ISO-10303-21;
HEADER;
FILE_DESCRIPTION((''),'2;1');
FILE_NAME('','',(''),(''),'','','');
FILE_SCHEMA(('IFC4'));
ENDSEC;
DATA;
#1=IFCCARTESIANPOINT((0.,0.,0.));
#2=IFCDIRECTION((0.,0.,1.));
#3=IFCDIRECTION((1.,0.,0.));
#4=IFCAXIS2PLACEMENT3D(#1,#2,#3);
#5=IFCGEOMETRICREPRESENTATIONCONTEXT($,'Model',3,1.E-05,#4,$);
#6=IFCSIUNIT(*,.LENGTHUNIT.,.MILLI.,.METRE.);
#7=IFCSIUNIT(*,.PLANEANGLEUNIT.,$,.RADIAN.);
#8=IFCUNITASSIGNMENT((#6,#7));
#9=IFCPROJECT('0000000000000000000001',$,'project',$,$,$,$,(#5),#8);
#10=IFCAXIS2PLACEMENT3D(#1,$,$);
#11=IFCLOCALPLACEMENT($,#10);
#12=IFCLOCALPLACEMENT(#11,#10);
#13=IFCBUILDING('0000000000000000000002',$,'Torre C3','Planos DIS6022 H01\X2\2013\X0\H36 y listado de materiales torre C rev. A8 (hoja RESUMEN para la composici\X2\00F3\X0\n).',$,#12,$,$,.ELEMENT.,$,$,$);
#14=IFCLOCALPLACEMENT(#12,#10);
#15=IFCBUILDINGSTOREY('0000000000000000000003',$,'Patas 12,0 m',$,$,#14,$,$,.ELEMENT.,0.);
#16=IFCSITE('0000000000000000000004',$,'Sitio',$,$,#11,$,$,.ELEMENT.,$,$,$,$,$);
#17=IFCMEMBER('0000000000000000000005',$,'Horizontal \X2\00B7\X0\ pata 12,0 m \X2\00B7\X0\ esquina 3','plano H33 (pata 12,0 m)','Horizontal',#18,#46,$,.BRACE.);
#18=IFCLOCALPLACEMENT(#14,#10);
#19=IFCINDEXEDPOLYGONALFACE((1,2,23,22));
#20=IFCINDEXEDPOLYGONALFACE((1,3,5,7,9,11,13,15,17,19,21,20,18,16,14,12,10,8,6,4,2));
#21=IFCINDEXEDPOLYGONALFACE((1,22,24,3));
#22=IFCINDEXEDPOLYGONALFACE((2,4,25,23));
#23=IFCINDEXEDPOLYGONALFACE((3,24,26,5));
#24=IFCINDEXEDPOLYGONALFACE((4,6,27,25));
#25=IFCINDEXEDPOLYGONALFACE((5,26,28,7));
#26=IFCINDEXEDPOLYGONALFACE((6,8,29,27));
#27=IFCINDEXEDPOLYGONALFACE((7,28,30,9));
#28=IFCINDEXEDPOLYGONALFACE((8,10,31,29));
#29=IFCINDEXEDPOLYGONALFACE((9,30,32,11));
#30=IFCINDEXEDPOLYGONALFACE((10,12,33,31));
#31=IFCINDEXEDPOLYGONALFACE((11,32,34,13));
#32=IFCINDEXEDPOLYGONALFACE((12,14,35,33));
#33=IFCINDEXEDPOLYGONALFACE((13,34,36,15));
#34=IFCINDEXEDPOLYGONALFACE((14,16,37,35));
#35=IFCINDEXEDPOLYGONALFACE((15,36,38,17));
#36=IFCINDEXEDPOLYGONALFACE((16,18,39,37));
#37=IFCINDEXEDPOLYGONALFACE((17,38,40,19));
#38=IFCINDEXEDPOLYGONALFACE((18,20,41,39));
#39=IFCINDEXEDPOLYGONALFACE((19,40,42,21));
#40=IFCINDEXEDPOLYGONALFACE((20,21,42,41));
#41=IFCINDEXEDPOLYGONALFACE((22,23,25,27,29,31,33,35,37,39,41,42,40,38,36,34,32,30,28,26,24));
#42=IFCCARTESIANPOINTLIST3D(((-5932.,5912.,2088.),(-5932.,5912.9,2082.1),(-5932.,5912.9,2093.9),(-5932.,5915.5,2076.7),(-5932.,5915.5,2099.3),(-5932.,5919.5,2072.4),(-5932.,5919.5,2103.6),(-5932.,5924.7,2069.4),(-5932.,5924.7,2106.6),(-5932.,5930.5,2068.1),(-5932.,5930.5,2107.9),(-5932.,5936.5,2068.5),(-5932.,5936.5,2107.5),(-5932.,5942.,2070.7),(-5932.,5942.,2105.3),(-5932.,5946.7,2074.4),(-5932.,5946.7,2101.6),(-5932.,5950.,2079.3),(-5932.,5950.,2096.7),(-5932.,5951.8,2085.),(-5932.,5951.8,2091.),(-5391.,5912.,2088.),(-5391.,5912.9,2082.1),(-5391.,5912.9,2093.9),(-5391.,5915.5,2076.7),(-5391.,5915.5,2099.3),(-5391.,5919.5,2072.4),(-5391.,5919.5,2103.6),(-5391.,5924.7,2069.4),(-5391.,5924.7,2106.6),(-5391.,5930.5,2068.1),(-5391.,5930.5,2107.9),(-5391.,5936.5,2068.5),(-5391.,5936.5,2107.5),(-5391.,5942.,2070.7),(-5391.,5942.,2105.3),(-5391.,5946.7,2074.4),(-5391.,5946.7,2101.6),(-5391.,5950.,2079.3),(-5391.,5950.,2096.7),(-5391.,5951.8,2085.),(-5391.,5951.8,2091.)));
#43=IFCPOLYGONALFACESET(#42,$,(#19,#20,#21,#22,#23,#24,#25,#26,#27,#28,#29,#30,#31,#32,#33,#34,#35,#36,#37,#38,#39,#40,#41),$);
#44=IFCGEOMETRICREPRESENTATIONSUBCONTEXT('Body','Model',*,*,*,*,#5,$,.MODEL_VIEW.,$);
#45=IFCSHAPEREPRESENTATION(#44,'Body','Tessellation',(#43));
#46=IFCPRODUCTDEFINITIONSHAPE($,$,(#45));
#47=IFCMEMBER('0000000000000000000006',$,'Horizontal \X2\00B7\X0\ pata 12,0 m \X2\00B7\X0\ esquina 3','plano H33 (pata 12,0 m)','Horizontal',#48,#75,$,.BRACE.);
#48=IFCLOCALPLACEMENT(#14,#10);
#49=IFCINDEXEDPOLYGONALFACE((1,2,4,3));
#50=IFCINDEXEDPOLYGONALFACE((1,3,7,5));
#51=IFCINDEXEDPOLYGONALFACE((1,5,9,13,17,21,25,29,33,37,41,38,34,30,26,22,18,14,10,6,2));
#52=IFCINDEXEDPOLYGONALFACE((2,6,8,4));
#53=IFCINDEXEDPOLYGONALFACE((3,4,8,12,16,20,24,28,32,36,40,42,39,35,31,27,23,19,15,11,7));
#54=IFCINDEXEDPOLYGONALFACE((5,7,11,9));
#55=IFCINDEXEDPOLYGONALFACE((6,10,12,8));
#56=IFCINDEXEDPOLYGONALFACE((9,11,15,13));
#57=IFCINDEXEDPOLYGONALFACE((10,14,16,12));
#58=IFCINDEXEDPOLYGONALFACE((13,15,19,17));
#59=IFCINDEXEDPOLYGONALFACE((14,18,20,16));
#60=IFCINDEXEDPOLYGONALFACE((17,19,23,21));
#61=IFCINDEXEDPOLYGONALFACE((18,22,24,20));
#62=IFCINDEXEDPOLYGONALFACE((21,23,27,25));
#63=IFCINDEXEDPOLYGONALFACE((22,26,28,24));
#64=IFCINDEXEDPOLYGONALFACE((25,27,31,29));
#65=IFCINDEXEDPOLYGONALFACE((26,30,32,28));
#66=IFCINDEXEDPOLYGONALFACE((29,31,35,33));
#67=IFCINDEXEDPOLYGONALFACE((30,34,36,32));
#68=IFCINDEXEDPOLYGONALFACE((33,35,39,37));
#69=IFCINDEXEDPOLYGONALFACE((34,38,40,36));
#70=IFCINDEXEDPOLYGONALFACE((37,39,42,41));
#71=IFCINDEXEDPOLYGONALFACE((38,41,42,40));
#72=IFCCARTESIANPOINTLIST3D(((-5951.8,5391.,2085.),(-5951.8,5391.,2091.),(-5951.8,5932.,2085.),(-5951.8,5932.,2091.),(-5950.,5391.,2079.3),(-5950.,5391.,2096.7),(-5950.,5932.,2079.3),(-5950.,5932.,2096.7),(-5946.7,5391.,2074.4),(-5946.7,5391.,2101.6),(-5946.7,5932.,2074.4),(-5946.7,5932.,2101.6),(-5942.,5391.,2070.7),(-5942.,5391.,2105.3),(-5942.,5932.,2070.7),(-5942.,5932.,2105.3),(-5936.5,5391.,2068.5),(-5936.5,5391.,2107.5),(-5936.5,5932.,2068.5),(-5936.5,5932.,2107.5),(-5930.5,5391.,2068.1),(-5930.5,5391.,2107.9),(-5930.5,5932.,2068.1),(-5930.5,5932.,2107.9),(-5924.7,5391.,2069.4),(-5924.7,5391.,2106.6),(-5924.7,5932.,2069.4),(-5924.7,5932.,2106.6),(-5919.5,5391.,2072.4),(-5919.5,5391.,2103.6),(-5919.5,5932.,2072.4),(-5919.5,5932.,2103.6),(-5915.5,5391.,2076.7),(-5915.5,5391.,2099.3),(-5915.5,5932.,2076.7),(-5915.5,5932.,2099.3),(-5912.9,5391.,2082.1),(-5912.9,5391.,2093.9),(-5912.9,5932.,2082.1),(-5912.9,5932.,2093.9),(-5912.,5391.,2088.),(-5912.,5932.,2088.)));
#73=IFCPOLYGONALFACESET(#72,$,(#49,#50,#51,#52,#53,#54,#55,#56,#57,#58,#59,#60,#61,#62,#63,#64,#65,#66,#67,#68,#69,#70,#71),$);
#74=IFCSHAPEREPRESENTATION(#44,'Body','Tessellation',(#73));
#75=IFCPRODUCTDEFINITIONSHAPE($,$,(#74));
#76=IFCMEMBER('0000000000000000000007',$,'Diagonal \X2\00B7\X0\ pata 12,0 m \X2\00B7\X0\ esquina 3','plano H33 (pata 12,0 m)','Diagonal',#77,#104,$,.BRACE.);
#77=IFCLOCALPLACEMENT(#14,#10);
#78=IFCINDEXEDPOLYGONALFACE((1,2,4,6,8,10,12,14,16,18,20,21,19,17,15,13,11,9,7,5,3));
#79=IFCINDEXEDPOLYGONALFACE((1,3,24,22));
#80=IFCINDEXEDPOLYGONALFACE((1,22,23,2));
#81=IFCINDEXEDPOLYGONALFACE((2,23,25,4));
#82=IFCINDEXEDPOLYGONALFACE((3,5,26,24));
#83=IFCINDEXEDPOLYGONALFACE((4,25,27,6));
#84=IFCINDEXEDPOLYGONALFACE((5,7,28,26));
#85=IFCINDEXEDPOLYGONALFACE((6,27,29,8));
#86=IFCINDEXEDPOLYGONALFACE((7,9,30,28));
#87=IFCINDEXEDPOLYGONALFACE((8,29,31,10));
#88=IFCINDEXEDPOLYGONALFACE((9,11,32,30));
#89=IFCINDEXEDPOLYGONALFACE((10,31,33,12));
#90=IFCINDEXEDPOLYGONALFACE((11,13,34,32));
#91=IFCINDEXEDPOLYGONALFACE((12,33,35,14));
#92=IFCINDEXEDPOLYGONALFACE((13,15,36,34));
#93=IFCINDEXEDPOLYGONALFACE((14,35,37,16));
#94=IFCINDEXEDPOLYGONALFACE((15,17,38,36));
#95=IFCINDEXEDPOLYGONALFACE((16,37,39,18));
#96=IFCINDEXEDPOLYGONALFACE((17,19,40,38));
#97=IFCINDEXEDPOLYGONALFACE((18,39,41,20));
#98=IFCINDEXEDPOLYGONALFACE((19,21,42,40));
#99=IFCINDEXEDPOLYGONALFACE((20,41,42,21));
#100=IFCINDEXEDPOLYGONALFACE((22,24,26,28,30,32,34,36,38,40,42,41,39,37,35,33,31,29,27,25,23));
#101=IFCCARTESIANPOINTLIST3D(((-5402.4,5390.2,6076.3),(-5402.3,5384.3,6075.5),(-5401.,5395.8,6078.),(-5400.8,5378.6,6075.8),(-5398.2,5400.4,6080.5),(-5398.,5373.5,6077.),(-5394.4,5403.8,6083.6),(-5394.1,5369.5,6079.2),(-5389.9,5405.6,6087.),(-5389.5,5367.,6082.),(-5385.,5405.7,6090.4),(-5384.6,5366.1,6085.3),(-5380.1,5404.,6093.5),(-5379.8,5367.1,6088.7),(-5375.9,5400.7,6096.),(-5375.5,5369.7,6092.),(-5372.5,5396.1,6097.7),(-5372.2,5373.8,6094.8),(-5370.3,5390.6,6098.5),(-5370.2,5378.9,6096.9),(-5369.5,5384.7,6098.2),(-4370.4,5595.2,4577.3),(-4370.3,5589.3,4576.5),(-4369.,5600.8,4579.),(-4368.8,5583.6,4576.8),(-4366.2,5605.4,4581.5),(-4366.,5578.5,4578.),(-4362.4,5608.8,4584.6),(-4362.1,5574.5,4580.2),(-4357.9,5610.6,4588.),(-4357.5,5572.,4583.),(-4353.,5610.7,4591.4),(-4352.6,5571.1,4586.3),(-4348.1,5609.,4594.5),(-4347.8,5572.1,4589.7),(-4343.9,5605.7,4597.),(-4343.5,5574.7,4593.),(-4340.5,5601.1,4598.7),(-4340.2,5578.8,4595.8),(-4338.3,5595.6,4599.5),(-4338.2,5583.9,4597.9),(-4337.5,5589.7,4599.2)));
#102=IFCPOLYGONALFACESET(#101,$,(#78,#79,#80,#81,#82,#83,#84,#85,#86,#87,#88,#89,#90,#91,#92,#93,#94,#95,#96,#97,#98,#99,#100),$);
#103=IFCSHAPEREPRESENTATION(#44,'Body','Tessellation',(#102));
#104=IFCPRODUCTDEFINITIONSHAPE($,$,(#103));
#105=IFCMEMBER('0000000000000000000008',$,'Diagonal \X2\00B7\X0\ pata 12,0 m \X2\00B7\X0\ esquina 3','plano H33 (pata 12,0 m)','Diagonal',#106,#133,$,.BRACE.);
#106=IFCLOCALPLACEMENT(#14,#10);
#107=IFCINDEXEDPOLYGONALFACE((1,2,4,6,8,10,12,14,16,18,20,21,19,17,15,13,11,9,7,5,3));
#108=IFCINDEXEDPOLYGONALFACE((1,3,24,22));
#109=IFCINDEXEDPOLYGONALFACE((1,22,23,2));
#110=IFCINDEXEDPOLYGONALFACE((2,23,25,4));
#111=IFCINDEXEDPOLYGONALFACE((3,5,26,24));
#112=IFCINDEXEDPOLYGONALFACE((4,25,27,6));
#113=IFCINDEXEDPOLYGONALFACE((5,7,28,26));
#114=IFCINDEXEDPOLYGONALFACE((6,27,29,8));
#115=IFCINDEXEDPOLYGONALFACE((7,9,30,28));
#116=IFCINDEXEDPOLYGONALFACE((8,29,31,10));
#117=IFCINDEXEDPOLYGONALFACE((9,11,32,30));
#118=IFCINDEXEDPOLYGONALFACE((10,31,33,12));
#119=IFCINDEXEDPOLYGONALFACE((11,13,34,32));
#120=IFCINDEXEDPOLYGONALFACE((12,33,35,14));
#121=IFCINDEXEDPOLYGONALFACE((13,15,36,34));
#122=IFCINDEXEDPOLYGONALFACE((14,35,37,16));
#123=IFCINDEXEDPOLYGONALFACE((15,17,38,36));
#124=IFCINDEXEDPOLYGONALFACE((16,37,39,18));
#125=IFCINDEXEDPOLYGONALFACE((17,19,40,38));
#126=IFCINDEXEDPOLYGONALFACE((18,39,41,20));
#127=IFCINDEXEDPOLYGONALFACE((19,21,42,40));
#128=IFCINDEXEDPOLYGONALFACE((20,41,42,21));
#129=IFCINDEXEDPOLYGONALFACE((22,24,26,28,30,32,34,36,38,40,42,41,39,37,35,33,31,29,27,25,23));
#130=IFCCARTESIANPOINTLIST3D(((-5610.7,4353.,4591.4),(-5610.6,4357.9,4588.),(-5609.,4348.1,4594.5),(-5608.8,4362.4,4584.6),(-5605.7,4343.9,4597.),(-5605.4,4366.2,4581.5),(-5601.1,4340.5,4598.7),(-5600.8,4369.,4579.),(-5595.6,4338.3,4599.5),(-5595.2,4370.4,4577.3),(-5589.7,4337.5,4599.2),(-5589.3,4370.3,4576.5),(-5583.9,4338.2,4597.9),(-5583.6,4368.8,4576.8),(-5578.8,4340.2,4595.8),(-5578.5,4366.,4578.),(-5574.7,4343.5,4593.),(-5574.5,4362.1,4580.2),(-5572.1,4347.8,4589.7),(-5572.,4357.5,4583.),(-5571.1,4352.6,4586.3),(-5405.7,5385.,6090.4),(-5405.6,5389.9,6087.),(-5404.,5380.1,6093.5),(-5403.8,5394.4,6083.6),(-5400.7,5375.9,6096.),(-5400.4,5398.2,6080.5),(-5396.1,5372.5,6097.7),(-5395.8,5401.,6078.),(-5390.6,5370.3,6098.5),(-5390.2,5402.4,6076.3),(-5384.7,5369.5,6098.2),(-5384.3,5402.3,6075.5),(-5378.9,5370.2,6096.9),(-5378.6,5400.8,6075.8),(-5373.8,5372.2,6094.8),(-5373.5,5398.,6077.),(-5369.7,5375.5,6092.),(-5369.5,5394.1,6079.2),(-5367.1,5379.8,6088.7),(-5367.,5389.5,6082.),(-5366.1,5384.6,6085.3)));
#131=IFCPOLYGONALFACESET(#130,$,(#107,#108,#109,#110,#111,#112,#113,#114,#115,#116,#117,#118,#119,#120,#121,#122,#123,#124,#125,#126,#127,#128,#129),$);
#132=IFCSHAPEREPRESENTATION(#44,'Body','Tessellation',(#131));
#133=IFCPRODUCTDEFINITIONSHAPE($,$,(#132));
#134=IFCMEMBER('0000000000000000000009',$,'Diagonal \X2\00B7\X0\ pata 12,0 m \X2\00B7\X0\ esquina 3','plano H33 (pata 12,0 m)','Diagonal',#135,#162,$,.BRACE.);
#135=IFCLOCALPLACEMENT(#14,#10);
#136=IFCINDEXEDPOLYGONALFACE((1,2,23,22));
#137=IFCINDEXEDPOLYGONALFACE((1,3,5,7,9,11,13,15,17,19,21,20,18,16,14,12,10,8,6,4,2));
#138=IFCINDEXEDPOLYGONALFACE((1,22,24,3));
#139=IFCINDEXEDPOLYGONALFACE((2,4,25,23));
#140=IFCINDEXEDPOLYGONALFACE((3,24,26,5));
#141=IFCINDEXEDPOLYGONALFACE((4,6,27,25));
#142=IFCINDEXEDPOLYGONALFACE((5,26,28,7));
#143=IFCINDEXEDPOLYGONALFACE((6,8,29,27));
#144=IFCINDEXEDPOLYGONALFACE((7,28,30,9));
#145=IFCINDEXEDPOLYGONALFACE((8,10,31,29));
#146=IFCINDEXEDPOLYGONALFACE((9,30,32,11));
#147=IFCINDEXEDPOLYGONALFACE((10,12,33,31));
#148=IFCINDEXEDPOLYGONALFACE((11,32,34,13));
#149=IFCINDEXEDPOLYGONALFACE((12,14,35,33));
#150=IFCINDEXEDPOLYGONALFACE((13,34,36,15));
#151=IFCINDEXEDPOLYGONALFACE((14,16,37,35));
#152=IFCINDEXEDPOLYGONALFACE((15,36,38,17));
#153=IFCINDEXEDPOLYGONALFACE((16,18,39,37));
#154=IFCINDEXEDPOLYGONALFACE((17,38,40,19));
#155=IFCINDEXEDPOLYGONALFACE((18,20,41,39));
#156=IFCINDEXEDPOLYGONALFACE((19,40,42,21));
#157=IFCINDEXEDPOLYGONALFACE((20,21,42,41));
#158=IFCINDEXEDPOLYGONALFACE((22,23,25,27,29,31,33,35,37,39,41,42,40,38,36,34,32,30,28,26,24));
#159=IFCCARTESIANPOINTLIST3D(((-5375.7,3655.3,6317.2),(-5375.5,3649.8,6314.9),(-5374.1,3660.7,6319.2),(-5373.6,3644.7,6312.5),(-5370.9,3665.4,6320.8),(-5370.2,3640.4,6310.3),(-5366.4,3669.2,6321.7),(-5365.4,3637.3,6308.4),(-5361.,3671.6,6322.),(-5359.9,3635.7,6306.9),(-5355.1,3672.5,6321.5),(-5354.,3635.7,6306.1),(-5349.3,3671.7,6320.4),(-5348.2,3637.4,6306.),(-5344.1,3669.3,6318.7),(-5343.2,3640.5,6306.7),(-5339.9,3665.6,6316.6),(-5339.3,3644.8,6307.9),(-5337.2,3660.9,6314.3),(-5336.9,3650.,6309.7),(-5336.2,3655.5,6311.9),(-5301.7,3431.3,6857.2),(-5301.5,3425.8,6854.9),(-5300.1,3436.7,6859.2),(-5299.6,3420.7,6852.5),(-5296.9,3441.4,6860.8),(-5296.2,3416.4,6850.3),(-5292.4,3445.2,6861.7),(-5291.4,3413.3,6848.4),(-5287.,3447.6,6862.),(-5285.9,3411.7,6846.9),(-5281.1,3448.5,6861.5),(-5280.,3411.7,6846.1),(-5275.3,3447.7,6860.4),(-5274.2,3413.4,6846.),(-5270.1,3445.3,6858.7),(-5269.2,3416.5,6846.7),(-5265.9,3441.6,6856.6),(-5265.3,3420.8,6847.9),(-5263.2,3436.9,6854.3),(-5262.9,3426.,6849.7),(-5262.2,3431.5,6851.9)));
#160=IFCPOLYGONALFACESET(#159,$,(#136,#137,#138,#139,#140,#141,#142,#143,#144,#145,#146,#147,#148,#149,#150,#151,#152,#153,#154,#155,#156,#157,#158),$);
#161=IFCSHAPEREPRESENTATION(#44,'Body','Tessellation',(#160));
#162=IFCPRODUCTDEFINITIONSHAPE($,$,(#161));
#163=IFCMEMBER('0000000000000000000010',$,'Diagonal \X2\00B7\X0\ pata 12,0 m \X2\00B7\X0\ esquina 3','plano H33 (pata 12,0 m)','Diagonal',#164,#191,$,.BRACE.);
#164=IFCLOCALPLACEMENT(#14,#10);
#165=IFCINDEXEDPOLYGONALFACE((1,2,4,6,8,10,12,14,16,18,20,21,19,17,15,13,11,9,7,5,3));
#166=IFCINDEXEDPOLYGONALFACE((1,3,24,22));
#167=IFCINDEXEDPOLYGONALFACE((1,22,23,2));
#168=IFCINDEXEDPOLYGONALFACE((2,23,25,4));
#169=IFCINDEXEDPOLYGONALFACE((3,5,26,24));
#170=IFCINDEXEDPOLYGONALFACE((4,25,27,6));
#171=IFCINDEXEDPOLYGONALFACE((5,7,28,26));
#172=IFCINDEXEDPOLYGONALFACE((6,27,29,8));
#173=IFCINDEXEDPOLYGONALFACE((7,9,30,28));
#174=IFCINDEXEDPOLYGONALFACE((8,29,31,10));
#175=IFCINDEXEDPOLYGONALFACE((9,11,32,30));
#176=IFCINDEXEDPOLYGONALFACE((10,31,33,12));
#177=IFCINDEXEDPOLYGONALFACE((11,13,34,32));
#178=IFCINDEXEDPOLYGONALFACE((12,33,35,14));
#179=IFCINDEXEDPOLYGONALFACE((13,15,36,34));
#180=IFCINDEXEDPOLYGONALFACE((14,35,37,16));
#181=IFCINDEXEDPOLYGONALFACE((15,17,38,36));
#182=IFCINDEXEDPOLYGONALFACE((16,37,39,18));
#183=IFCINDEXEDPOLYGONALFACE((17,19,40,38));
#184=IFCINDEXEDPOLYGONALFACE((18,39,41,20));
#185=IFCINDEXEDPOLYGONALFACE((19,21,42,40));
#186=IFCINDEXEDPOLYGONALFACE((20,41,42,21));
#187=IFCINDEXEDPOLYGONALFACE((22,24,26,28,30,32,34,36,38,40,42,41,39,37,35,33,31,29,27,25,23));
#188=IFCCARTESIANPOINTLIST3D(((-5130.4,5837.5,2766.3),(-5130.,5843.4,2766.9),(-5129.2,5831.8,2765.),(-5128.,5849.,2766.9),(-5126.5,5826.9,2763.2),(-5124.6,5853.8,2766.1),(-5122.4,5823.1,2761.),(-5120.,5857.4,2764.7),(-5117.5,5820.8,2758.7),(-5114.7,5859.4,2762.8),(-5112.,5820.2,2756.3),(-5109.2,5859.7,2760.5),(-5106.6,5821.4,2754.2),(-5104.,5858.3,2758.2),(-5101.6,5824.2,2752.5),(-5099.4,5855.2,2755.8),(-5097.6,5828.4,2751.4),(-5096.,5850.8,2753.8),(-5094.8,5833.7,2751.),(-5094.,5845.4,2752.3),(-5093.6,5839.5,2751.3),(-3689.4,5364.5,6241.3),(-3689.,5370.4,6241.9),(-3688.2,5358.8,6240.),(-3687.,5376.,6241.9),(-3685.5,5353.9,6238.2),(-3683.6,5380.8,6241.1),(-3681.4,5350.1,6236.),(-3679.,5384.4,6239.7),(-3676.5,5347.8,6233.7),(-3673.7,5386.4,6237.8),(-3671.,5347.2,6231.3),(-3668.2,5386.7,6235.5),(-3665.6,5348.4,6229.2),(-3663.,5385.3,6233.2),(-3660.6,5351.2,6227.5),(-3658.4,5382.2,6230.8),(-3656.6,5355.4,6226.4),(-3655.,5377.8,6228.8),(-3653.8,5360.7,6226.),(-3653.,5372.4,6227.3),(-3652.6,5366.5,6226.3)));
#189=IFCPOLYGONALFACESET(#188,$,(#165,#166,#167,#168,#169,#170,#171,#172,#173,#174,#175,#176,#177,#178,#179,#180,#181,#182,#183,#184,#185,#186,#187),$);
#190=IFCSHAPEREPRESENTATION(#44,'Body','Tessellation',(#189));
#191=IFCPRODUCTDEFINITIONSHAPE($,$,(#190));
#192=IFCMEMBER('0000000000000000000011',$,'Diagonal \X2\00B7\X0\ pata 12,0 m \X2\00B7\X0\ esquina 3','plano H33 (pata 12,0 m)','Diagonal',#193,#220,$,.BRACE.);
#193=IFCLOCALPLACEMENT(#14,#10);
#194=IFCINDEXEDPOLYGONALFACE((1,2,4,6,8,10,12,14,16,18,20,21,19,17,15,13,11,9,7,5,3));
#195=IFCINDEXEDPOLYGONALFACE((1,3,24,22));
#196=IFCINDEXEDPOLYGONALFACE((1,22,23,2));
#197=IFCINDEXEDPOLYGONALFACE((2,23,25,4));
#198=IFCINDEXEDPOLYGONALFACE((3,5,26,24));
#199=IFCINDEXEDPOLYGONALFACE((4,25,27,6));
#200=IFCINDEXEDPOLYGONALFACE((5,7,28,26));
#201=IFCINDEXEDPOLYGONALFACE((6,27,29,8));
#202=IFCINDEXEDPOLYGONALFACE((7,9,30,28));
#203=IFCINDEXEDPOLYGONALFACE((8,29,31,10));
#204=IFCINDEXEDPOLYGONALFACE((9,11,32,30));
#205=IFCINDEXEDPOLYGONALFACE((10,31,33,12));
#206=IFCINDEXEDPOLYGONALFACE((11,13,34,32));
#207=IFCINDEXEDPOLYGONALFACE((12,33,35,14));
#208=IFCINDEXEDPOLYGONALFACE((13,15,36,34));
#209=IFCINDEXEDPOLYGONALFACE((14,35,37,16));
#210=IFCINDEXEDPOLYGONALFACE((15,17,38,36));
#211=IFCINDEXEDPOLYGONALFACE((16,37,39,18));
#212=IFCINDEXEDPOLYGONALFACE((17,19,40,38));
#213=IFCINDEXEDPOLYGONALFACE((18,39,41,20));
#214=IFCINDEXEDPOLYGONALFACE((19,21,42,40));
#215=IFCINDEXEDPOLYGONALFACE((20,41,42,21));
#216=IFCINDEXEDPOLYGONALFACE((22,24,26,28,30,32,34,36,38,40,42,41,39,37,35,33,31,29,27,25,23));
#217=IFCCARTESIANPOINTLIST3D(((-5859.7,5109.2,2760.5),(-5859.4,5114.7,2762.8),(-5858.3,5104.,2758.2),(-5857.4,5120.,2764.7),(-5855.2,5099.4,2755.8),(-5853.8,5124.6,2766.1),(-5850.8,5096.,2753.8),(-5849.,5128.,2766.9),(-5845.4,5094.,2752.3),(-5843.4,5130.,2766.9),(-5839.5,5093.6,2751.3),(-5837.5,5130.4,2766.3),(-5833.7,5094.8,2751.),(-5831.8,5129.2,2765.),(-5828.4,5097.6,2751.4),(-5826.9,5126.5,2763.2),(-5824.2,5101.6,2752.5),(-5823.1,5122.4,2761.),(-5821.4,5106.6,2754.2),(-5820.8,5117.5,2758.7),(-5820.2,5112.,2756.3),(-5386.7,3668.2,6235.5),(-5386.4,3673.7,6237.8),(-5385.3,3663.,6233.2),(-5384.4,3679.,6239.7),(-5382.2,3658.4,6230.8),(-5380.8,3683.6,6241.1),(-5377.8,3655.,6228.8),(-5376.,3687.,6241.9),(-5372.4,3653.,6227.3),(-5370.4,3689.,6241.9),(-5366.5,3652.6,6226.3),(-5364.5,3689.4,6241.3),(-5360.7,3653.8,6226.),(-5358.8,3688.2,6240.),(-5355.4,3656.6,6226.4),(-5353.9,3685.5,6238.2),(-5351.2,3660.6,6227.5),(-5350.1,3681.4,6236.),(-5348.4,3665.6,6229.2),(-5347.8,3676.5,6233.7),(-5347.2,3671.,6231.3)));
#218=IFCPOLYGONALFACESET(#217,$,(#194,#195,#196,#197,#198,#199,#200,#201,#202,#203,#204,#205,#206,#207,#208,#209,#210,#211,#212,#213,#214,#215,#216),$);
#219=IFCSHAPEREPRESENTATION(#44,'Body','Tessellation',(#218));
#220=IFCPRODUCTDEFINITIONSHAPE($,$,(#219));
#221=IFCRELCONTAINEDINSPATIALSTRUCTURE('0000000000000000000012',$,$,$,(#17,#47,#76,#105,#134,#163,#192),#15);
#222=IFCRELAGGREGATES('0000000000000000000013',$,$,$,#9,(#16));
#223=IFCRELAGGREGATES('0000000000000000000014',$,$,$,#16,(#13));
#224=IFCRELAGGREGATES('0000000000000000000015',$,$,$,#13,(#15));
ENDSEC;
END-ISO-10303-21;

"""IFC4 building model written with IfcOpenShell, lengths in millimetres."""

from ifc_helpers import new_model, si_unit, frame, origin, origin_with_axes, place, context, subcontext, project, spatial, circle, extrude, element, save


model = new_model("IFC4")

# Units and contexts
model_context = context("Model", 3, precision=1e-05, world=origin_with_axes())
body_context = subcontext(model_context, "Body", "Model", "MODEL_VIEW")
ifc_project = project(units=[si_unit("LENGTHUNIT", "METRE", prefix="MILLI"), si_unit("PLANEANGLEUNIT", "RADIAN")], contexts=[model_context])

# Site, building, storey
site_placement = place(None, origin())
site = spatial("IfcSite", under=ifc_project, at=site_placement, Name="Sitio", CompositionType="ELEMENT")
building_placement = place(site_placement, origin())
building = spatial("IfcBuilding", under=site, at=building_placement, Name="Torre C3", Description="Planos DIS6022 H01–H36 y listado de materiales torre C rev. A8 (hoja RESUMEN para la composición).", CompositionType="ELEMENT")
storey_placement = place(building_placement, origin())
storey = spatial("IfcBuildingStorey", under=building, at=storey_placement, Name="Patas 12,0 m", CompositionType="ELEMENT", Elevation=0.0)

# Members
for number, where, z_axis, x_axis, name in (
    (1, (-5391.0, 5932.0, 2088.0), (-1.0, 0.0, 0.0), (0.0, -1.0, 0.0), "Horizontal · pata 12,0 m · esquina 3"),
    (2, (-5932.0, 5391.0, 2088.0), (0.0, 1.0, 0.0), (1.0, 0.0, 0.0), "Horizontal · pata 12,0 m · esquina 3"),
):
    element("IfcMember", number, at=place(storey_placement, frame(where, z_axis=z_axis, x_axis=x_axis)), inside=storey, Name=name, Description="plano H33 (pata 12,0 m)", ObjectType="Horizontal", PredefinedType="BRACE", context=body_context, shape_type="SweptSolid", body=[
        extrude(circle(Radius=20.0), None, (0.0, 0.0, 1.0), 541.0),
    ])
for number, where, z_axis, x_axis, name in (
    (3, (-5386.0, 5386.0, 6087.0), (0.563501, 0.111936, -0.818497), (0.522638, -0.815603, 0.248275), "Diagonal · pata 12,0 m · esquina 3"),
    (4, (-5386.0, 5386.0, 6087.0), (-0.111936, -0.563501, -0.818497), (0.815603, -0.522638, 0.248275), "Diagonal · pata 12,0 m · esquina 3"),
):
    element("IfcMember", number, at=place(storey_placement, frame(where, z_axis=z_axis, x_axis=x_axis)), inside=storey, Name=name, Description="plano H33 (pata 12,0 m)", ObjectType="Diagonal", PredefinedType="BRACE", context=body_context, shape_type="SweptSolid", body=[
        extrude(circle(Radius=20.0), None, (0.0, 0.0, 1.0), 1831.4),
    ])
member_1_placement = place(storey_placement, frame((-5282.0, 3430.0, 6854.0), z_axis=(-0.125577, 0.380124, -0.916371), x_axis=(0.83534, -0.457784, -0.304368)))
element("IfcMember", 5, at=member_1_placement, inside=storey, Name="Diagonal · pata 12,0 m · esquina 3", Description="plano H33 (pata 12,0 m)", ObjectType="Diagonal", PredefinedType="BRACE", context=body_context, shape_type="SweptSolid", body=[
    extrude(circle(Radius=20.0), None, (0.0, 0.0, 1.0), 589.3),
])
for number, where, z_axis, x_axis, name in (
    (6, (-3671.0, 5367.0, 6234.0), (-0.380056, 0.124751, -0.916512), (0.520039, -0.790608, -0.323262), "Diagonal · pata 12,0 m · esquina 3"),
    (7, (-5367.0, 3671.0, 6234.0), (-0.124751, 0.380056, -0.916512), (0.790608, -0.520039, -0.323262), "Diagonal · pata 12,0 m · esquina 3"),
):
    element("IfcMember", number, at=place(storey_placement, frame(where, z_axis=z_axis, x_axis=x_axis)), inside=storey, Name=name, Description="plano H33 (pata 12,0 m)", ObjectType="Diagonal", PredefinedType="BRACE", context=body_context, shape_type="SweptSolid", body=[
        extrude(circle(Radius=20.0), None, (0.0, 0.0, 1.0), 3791.5),
    ])

save(model, "model.ifc")
